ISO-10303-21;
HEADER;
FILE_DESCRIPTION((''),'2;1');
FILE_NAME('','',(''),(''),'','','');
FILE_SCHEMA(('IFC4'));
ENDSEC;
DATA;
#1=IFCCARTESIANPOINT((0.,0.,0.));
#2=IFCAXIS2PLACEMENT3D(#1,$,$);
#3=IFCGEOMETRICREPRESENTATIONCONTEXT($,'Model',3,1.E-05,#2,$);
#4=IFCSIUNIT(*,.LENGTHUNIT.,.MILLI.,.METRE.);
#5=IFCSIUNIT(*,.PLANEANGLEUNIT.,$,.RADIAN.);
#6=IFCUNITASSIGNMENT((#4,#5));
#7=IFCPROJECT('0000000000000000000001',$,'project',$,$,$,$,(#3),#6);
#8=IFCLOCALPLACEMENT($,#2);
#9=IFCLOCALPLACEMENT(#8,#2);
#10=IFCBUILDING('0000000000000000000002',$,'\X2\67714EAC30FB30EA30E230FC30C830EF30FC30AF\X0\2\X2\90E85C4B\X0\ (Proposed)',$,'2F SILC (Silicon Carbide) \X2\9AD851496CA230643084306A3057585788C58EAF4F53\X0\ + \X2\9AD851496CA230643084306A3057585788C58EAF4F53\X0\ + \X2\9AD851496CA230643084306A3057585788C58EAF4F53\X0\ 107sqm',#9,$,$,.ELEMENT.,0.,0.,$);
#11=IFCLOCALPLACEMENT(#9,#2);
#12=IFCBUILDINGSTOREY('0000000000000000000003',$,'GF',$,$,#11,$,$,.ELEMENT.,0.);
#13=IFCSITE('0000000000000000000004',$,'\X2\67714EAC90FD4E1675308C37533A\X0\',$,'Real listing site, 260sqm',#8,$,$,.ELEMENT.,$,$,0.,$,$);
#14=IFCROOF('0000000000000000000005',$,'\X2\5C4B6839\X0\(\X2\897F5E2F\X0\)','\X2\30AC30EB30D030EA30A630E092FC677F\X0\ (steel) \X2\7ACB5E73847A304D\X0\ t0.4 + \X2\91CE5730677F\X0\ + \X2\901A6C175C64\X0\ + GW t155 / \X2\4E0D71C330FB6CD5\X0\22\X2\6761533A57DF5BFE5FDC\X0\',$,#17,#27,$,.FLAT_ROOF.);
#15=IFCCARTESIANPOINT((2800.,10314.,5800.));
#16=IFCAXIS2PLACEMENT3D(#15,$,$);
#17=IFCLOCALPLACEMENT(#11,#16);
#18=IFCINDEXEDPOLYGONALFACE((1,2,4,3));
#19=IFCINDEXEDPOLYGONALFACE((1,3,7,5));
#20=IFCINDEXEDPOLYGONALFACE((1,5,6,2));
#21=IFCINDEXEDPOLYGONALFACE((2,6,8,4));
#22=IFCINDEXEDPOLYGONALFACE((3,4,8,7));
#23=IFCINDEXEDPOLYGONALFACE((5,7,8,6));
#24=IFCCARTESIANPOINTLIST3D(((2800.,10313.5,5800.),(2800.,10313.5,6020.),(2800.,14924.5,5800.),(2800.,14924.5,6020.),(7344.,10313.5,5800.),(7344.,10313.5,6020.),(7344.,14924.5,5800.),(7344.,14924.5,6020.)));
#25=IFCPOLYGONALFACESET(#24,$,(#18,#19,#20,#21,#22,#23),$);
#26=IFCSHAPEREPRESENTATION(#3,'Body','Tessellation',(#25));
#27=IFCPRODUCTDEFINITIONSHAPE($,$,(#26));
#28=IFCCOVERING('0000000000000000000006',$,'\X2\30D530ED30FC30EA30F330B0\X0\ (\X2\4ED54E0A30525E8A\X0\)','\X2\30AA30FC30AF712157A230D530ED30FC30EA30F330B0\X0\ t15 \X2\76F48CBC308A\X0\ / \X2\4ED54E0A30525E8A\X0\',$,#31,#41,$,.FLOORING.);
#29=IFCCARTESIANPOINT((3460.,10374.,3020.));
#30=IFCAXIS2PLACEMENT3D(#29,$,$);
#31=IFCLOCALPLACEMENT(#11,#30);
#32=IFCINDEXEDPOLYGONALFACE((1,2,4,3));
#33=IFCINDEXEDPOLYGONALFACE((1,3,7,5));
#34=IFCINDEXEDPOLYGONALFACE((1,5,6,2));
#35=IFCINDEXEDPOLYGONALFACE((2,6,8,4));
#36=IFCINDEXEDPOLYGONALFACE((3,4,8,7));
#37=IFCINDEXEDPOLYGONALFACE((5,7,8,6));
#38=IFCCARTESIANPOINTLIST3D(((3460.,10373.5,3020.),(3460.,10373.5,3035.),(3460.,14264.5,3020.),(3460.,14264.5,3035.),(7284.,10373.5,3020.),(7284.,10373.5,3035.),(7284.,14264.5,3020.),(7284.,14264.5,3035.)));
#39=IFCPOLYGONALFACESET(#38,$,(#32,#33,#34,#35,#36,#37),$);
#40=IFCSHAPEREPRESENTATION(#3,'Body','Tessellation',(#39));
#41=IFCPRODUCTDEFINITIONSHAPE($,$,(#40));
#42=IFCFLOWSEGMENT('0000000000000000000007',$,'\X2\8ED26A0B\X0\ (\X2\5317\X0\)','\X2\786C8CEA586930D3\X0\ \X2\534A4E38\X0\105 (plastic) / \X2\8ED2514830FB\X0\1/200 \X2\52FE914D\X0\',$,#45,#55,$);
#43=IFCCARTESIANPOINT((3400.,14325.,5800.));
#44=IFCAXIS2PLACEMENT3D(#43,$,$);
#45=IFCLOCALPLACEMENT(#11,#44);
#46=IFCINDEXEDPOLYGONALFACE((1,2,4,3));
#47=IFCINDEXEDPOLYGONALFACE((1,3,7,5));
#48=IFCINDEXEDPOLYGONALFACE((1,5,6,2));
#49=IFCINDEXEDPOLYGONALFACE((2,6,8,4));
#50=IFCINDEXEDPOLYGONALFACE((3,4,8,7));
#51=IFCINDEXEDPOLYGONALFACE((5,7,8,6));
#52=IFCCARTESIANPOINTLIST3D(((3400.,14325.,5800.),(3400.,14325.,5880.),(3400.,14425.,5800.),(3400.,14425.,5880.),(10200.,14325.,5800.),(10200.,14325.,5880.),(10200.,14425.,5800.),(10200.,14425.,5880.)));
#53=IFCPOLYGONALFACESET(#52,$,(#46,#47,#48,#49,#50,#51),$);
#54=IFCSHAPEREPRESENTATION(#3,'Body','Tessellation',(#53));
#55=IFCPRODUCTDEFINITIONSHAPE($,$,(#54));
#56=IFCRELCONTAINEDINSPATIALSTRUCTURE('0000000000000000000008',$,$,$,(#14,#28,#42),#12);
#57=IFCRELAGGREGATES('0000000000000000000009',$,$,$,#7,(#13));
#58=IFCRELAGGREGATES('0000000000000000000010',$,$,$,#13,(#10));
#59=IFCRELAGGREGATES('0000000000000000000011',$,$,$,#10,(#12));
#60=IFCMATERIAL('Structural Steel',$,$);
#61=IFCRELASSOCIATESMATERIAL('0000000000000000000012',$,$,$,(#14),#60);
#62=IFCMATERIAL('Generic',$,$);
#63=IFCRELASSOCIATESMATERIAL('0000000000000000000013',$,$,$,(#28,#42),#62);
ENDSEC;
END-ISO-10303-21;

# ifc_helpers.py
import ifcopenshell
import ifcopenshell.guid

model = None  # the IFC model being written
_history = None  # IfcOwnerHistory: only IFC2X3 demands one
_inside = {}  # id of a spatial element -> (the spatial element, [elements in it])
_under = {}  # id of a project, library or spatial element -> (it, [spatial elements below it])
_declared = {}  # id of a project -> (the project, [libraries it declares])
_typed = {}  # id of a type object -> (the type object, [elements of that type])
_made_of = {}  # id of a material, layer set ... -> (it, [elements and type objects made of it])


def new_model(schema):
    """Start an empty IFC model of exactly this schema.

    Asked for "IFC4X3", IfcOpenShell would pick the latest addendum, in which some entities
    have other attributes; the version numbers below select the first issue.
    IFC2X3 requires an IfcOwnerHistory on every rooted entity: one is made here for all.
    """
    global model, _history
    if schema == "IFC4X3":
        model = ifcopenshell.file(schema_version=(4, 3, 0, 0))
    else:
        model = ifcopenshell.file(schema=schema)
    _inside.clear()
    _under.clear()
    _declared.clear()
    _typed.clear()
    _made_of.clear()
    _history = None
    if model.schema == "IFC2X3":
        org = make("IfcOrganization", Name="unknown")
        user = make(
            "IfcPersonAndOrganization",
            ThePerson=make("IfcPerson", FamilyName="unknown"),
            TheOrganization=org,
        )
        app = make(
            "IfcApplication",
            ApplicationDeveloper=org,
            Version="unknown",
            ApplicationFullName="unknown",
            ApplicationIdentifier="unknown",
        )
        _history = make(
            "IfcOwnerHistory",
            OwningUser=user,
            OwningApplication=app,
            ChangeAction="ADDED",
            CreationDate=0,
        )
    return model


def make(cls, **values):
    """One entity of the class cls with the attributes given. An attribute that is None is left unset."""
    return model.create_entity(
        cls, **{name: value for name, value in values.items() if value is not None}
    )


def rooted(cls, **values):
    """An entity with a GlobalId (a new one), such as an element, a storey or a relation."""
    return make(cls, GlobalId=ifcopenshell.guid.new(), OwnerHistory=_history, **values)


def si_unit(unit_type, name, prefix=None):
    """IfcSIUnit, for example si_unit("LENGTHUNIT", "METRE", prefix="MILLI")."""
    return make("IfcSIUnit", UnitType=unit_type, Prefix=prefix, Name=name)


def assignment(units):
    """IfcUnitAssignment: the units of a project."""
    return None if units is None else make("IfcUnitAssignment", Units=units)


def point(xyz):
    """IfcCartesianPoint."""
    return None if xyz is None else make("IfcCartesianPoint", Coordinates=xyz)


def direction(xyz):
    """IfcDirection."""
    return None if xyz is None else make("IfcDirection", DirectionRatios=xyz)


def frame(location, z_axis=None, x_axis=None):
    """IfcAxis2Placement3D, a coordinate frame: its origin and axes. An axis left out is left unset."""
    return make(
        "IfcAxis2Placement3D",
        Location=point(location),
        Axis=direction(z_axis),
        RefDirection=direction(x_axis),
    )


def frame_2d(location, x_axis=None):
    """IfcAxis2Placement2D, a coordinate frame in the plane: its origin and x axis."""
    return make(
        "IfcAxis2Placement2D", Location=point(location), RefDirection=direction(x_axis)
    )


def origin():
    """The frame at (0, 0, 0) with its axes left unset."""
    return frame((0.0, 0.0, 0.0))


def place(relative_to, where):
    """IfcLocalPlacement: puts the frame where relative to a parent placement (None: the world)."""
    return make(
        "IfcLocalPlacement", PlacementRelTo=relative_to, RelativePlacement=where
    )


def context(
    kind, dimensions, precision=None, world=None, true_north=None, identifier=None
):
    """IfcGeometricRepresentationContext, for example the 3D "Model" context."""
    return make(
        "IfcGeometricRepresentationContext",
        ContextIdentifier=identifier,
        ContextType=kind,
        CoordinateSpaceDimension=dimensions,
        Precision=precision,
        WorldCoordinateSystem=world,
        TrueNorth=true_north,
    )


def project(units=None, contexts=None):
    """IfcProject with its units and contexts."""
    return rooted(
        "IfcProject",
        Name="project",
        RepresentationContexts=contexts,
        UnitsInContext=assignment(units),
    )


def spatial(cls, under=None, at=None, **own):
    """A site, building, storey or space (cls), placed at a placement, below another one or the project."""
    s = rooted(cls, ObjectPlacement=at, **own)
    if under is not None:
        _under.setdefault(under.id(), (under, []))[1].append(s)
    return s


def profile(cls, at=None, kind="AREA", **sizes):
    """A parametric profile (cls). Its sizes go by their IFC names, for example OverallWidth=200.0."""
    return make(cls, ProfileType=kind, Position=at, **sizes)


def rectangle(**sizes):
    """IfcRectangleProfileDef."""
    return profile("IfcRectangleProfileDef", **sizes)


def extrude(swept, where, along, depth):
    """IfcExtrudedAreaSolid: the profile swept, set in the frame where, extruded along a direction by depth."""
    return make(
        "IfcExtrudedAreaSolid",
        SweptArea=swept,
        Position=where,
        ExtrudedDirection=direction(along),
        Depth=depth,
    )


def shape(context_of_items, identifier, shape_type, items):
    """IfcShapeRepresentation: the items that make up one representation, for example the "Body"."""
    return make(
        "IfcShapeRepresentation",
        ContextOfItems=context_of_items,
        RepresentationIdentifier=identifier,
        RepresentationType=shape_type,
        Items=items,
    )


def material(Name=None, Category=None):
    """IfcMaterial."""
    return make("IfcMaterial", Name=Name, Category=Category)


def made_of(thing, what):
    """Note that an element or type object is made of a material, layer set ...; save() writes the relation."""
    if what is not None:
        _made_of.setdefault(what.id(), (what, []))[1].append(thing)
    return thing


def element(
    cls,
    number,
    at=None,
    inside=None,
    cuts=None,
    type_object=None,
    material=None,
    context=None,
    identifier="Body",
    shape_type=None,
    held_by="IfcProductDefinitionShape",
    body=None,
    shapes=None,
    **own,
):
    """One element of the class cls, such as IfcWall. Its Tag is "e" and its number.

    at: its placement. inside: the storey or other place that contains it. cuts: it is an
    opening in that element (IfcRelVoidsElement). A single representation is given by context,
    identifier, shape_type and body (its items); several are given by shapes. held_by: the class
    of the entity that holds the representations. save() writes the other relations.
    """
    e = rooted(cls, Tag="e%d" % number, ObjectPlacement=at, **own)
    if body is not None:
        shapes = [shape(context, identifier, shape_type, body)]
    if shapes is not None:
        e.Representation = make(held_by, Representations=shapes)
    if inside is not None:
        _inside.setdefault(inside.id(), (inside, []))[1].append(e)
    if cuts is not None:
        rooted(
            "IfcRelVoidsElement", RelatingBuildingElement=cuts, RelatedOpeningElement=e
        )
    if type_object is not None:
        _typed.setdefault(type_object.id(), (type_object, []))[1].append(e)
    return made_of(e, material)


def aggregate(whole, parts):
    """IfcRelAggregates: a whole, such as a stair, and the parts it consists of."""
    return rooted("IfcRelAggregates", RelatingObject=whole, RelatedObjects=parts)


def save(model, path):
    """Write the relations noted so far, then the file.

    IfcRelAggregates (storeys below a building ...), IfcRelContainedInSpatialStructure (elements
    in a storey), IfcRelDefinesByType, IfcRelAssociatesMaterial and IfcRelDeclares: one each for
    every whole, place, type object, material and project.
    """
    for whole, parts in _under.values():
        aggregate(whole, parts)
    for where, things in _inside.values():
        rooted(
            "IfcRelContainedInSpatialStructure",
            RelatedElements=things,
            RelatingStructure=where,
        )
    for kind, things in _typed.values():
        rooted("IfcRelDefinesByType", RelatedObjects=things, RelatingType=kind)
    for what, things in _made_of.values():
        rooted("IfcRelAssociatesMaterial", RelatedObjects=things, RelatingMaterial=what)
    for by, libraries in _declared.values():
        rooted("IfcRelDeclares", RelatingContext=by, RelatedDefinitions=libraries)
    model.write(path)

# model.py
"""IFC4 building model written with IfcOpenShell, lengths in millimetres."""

from ifc_helpers import new_model, si_unit, frame, frame_2d, origin, place, context, project, spatial, rectangle, extrude, material, element, save


model = new_model("IFC4")

# Units and contexts
model_context = context("Model", 3, precision=1e-05, world=origin())
ifc_project = project(units=[si_unit("LENGTHUNIT", "METRE", prefix="MILLI"), si_unit("PLANEANGLEUNIT", "RADIAN")], contexts=[model_context])

# Site, building, storey
site_placement = place(None, origin())
site = spatial("IfcSite", under=ifc_project, at=site_placement, Name="東京都世田谷区", ObjectType="Real listing site, 260sqm", CompositionType="ELEMENT", RefElevation=0.0)
building_placement = place(site_placement, origin())
building = spatial("IfcBuilding", under=site, at=building_placement, Name="東京・リモートワーク2部屋 (Proposed)", ObjectType="2F SILC (Silicon Carbide) 高光沢つやなし塗装躯体 + 高光沢つやなし塗装躯体 + 高光沢つやなし塗装躯体 107sqm", CompositionType="ELEMENT", ElevationOfRefHeight=0.0, ElevationOfTerrain=0.0)
storey_placement = place(building_placement, origin())
storey = spatial("IfcBuildingStorey", under=building, at=storey_placement, Name="GF", CompositionType="ELEMENT", Elevation=0.0)

# Roof
ifc_material_1 = material(Name="Structural Steel")
for number, where, name in (
    (1, (2800.0, 10314.0, 5800.0), "屋根(西帯)"),
):
    element("IfcRoof", number, at=place(storey_placement, frame(where)), inside=storey, material=ifc_material_1, Name=name, Description="ガルバリウム鋼板 (steel) 立平葺き t0.4 + 野地板 + 通気層 + GW t155 / 不燃・法22条区域対応", PredefinedType="FLAT_ROOF", context=model_context, shape_type="SweptSolid", body=[
        extrude(rectangle(XDim=4544.0, YDim=4611.0, at=frame_2d((2272.0, 2305.0))), frame((2800.0, 10314.0, 5800.0)), (0.0, 0.0, 1.0), 220.0),
    ])

# Covering
ifc_material_2 = material(Name="Generic")
covering_placement = place(storey_placement, frame((3460.0, 10374.0, 3020.0)))
element("IfcCovering", 2, at=covering_placement, inside=storey, material=ifc_material_2, Name="フローリング (仕上げ床)", Description="オーク無垢フローリング t15 直貼り / 仕上げ床", PredefinedType="FLOORING", context=model_context, shape_type="SweptSolid", body=[
    extrude(rectangle(XDim=3824.0, YDim=3891.0, at=frame_2d((1912.0, 1945.0))), frame((3460.0, 10374.0, 3020.0)), (0.0, 0.0, 1.0), 15.0),
])

# Flow segment
flow_segment_placement = place(storey_placement, frame((3400.0, 14325.0, 5800.0)))
element("IfcFlowSegment", 3, at=flow_segment_placement, inside=storey, material=ifc_material_2, Name="軒樋 (北)", Description="硬質塩ビ 半丸105 (plastic) / 軒先・1/200 勾配", context=model_context, shape_type="SweptSolid", body=[
    extrude(rectangle(XDim=6800.0, YDim=100.0, at=frame_2d((3400.0, 50.0))), frame((3400.0, 14325.0, 5800.0)), (0.0, 0.0, 1.0), 80.0),
])

save(model, "model.ifc")
